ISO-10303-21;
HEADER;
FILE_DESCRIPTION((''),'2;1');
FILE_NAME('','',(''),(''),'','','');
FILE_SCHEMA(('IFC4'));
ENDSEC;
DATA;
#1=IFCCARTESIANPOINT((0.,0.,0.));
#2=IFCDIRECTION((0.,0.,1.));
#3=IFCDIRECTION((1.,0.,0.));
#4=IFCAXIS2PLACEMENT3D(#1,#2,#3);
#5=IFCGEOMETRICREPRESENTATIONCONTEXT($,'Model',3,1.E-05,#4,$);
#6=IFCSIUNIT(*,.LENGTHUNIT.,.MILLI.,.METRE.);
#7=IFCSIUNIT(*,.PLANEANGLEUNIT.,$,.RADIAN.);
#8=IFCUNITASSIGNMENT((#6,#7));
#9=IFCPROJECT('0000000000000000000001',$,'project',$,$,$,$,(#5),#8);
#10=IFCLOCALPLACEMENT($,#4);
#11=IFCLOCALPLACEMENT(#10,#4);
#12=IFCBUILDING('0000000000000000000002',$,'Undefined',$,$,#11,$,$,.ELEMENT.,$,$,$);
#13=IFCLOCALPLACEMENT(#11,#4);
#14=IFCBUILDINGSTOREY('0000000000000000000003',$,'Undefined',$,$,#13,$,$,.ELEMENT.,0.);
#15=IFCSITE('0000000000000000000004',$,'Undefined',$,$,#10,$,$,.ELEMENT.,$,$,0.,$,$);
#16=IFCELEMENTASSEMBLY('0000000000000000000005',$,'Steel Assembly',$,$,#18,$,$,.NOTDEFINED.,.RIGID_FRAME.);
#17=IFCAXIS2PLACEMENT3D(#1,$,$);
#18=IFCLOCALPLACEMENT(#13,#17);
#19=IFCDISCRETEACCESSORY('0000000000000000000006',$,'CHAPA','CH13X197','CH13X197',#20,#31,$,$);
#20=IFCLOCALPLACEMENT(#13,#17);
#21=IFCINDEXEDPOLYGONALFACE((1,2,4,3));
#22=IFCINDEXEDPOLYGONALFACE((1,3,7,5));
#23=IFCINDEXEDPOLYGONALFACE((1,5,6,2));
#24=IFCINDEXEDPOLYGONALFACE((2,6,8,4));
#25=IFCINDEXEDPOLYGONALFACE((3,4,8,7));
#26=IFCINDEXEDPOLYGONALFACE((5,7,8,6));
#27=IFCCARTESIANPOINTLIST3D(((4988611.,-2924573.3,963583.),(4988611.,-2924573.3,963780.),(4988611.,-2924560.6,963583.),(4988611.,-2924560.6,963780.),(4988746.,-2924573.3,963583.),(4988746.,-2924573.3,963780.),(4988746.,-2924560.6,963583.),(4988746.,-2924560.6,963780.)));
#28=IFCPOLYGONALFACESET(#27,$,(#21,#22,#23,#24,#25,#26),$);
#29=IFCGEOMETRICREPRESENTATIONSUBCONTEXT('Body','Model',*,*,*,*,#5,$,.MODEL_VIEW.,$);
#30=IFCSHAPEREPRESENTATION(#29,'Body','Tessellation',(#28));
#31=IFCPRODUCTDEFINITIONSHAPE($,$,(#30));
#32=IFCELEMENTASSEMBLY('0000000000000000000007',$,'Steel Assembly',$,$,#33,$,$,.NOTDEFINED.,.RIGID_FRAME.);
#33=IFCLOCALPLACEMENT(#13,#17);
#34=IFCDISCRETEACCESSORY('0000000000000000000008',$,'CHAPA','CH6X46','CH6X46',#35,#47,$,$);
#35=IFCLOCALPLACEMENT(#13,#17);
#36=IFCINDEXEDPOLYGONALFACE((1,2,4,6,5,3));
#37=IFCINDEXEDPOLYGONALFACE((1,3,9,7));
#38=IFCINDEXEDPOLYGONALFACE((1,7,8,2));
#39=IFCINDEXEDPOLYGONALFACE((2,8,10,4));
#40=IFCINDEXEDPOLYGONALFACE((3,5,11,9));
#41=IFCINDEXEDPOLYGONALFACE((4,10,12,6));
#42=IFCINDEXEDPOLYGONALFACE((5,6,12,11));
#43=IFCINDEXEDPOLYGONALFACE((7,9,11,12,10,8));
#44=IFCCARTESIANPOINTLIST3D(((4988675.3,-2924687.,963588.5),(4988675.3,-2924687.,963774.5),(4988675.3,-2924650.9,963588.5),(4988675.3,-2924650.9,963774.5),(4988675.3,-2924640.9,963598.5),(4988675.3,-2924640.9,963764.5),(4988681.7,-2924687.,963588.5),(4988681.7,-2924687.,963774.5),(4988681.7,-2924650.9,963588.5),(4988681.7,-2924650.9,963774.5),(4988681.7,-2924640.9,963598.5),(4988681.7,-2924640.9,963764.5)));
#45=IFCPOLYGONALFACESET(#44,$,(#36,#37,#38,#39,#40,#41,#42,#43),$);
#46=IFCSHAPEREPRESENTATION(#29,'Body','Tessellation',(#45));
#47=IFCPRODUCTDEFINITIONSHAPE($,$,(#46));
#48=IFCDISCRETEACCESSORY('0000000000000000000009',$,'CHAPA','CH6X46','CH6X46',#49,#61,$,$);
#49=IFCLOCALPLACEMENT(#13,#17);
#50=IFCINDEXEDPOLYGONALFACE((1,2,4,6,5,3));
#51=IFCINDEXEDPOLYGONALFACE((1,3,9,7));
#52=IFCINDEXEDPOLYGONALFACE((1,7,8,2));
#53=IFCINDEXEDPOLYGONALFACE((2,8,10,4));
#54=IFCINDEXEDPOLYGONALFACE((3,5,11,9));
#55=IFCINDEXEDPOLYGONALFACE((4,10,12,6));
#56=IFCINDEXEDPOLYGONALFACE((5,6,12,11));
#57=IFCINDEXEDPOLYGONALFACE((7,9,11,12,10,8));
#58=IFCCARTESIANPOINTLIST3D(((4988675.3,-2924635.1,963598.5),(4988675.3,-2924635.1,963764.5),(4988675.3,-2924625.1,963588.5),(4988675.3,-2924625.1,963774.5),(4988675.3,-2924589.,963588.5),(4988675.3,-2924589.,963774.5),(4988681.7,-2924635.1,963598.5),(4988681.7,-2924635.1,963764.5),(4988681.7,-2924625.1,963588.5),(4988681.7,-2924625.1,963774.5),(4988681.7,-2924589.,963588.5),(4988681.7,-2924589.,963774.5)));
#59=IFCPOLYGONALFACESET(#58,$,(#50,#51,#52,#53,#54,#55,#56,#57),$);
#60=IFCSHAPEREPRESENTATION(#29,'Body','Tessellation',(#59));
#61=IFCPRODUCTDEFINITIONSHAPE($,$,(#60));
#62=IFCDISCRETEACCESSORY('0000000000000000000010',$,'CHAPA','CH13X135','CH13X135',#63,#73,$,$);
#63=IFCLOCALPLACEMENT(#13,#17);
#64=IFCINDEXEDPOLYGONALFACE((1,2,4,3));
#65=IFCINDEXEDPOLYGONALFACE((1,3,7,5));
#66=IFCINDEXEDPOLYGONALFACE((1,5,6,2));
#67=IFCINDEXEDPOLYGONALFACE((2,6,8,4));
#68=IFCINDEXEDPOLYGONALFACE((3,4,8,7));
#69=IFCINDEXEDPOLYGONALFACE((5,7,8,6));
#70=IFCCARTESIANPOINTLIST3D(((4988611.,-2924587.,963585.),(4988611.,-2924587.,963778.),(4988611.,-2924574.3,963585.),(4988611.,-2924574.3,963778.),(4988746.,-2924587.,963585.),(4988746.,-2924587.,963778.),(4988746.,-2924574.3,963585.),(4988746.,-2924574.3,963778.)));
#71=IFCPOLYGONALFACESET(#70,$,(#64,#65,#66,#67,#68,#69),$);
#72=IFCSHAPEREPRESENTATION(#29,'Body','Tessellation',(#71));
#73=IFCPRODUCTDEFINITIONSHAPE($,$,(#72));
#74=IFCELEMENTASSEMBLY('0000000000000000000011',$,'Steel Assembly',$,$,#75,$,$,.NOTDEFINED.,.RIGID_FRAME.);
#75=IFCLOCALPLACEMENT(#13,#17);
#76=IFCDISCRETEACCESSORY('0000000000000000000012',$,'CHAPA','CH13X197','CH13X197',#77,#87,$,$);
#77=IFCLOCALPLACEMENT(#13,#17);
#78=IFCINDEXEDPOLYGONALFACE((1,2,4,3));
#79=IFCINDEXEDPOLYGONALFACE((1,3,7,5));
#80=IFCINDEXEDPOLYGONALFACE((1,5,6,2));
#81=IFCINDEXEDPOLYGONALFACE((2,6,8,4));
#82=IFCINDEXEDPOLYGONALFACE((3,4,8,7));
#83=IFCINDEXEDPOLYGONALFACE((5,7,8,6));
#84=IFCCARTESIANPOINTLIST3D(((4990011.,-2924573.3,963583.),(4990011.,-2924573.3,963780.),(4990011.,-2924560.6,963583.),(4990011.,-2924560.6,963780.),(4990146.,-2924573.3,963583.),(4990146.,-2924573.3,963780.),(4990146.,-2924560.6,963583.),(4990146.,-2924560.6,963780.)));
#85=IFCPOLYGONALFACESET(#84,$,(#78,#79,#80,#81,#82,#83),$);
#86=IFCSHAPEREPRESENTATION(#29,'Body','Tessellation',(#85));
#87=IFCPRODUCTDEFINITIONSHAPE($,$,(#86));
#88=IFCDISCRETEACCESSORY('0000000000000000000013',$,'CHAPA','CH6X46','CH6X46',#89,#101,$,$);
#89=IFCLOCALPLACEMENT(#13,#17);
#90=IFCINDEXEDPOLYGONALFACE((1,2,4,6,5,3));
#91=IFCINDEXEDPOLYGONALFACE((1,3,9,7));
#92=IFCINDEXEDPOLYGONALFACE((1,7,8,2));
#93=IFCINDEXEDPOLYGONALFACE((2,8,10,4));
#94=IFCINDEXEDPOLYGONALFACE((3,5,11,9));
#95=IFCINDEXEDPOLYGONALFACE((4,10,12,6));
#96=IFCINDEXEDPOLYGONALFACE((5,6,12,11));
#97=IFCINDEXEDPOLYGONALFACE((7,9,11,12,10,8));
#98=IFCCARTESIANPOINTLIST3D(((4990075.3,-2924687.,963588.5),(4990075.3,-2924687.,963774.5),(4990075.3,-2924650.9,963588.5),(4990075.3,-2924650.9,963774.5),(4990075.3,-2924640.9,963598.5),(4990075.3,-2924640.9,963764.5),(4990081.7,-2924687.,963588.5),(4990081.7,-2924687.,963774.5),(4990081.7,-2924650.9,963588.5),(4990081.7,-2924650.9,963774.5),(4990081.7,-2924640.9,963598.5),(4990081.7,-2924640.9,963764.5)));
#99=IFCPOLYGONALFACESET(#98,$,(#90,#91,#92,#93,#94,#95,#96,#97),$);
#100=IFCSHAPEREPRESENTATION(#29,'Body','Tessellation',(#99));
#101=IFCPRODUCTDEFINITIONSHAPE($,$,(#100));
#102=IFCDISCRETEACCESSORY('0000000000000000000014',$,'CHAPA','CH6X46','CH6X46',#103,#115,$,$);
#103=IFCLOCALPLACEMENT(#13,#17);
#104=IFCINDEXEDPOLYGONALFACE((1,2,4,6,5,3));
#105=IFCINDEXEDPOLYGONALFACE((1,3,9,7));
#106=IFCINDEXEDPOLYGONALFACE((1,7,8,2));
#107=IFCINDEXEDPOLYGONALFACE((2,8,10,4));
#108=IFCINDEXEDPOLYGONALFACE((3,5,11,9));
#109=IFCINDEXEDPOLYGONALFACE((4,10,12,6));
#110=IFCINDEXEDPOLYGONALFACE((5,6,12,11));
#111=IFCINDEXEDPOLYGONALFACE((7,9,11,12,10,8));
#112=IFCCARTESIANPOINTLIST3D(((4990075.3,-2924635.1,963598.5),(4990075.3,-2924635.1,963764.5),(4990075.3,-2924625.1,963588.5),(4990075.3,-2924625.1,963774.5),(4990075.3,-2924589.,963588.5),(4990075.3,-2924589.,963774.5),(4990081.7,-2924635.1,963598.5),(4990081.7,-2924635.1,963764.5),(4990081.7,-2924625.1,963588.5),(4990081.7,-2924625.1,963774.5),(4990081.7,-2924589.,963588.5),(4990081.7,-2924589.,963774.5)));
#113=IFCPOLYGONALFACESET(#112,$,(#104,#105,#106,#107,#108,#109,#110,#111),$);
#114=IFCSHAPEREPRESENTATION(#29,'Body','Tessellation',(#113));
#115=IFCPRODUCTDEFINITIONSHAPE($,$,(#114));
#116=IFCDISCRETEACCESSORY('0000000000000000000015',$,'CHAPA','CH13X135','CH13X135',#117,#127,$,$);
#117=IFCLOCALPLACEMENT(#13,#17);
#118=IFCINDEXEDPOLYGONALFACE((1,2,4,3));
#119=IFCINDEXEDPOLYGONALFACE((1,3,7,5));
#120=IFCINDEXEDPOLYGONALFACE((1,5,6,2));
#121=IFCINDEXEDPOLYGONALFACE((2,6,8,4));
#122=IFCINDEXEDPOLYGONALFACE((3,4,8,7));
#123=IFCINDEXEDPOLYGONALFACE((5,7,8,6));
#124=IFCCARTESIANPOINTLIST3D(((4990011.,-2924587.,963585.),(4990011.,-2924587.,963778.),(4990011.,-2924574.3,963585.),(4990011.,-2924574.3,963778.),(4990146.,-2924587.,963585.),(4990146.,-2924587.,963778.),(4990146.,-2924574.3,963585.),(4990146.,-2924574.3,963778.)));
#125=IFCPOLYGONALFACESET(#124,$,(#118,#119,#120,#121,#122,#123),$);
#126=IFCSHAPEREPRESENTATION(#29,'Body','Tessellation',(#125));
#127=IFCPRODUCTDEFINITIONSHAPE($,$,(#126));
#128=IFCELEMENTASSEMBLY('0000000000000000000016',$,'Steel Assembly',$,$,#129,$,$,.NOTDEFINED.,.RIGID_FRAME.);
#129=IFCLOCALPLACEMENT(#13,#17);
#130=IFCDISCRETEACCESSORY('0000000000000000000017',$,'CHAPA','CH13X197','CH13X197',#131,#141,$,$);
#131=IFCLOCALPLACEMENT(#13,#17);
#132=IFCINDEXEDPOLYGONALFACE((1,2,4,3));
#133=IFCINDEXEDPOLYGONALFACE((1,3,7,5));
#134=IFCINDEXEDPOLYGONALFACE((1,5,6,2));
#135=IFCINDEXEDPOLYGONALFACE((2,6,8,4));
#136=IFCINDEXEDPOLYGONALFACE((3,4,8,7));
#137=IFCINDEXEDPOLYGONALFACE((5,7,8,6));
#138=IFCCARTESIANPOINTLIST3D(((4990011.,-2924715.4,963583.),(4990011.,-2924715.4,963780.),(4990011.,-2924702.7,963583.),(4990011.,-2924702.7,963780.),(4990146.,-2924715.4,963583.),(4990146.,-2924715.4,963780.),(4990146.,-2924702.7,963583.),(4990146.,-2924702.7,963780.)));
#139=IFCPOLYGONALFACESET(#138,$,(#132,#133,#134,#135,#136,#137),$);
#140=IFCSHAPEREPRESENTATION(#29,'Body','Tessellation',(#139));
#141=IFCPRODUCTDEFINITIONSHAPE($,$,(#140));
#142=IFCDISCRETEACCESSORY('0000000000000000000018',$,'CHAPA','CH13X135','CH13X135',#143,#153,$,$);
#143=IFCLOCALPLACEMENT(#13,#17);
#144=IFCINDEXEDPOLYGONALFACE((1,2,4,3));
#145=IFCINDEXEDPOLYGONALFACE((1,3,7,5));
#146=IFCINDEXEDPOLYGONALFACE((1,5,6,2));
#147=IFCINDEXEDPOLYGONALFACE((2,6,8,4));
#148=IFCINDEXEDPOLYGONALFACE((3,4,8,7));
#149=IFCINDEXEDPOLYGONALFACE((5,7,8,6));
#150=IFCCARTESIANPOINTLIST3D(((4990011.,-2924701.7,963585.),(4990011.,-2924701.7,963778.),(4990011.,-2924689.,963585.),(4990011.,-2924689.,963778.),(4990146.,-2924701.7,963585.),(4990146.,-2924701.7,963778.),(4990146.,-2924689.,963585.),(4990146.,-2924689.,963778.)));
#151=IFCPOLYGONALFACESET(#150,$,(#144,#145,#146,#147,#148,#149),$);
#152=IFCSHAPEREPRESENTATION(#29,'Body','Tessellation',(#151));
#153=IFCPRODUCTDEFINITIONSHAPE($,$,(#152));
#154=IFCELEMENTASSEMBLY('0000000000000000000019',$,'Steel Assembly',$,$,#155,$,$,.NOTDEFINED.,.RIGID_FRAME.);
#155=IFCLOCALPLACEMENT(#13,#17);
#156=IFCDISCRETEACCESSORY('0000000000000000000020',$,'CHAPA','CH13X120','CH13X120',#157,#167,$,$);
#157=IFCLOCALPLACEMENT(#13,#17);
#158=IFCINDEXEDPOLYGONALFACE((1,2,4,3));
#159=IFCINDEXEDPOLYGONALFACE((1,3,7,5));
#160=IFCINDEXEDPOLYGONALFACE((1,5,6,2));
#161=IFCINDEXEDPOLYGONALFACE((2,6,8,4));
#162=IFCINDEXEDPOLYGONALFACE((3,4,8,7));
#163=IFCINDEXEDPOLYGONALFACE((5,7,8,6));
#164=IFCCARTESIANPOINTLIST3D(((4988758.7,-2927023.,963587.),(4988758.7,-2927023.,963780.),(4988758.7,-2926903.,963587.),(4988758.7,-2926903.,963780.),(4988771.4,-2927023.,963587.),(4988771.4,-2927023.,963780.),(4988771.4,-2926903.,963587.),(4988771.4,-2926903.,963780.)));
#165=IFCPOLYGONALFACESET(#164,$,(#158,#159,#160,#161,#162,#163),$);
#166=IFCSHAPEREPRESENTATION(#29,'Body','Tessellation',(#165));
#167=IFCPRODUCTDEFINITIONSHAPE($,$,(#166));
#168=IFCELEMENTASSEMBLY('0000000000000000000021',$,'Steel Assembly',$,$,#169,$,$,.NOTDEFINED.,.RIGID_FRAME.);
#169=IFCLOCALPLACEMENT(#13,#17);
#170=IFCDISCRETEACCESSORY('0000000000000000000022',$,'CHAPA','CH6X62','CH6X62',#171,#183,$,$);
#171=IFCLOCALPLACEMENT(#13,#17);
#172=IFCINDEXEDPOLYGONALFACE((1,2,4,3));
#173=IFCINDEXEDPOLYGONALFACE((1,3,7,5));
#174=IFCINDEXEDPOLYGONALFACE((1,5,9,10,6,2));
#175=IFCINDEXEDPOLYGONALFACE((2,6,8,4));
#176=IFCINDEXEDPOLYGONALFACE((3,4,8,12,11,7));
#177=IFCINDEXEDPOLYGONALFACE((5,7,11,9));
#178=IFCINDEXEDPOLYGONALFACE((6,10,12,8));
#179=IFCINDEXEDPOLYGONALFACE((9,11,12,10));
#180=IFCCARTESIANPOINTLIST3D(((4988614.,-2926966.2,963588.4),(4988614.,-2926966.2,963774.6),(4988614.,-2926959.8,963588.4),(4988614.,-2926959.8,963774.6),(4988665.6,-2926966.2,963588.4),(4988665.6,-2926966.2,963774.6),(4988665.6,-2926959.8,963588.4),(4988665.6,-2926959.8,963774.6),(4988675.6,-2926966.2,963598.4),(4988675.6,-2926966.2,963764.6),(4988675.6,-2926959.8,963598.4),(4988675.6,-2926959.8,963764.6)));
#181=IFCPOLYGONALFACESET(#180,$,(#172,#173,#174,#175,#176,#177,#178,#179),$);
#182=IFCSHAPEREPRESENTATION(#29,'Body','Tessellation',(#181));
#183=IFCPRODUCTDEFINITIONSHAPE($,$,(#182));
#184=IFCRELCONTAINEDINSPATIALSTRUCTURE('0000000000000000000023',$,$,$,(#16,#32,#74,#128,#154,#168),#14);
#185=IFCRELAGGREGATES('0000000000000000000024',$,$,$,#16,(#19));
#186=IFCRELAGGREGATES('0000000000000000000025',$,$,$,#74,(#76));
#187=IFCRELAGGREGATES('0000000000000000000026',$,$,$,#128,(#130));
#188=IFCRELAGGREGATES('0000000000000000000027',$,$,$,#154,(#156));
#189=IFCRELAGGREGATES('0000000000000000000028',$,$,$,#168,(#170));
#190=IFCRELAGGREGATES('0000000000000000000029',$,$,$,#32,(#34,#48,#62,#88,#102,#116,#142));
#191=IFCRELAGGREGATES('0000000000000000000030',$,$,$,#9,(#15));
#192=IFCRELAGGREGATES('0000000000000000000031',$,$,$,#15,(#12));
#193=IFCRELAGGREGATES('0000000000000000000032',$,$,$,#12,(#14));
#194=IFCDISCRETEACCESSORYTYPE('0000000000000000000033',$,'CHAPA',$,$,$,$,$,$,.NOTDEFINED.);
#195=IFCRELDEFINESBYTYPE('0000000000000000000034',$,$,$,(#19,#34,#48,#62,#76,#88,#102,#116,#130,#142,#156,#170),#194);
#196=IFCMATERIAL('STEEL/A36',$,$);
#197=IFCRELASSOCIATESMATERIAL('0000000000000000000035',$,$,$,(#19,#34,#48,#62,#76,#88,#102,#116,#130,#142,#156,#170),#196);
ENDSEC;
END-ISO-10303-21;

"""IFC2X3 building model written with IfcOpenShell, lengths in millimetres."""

from ifc_helpers import new_model, si_unit, frame, origin_with_axes, place, context, subcontext, project, spatial, polyline, outline, extrude, material, type_object, element, aggregate, save


model = new_model("IFC2X3")

# Units and contexts
model_context = context("Model", 3, precision=1e-05, world=origin_with_axes())
body_context = subcontext(model_context, "Body", "Model", "MODEL_VIEW")
ifc_project = project(units=[si_unit("LENGTHUNIT", "METRE", prefix="MILLI"), si_unit("PLANEANGLEUNIT", "RADIAN")], contexts=[model_context])

# Site, building, storey
site_placement = place(None, origin_with_axes())
site = spatial("IfcSite", under=ifc_project, at=site_placement, Name="Undefined", CompositionType="ELEMENT", RefElevation=0.0)
building_placement = place(site_placement, origin_with_axes())
building = spatial("IfcBuilding", under=site, at=building_placement, Name="Undefined", CompositionType="ELEMENT")
storey_placement = place(building_placement, origin_with_axes())
storey = spatial("IfcBuildingStorey", under=building, at=storey_placement, Name="Undefined", CompositionType="ELEMENT", Elevation=0.0)

# Element assembly, discrete accessory
assembly_1_placement = place(storey_placement, origin_with_axes())
assembly_1 = element("IfcElementAssembly", 1, at=assembly_1_placement, inside=storey, Name="Steel Assembly", AssemblyPlace="NOTDEFINED", PredefinedType="RIGID_FRAME")
ifc_material_1 = material(Name="STEEL/A36")
discrete_accessory_type_1 = type_object("IfcDiscreteAccessoryType", Name="CHAPA")
discrete_accessory_1_placement = place(assembly_1_placement, frame((4988678.5, -2924567.0, 963780.0), z_axis=(0.0, 1.0, 0.0), x_axis=(0.0, 0.0, -1.0)))
discrete_accessory_1 = element("IfcDiscreteAccessory", 2, at=discrete_accessory_1_placement, type_object=discrete_accessory_type_1, material=ifc_material_1, Name="CHAPA", Description="CH13X197", ObjectType="CH13X197", context=body_context, shape_type="SweptSolid", body=[
    extrude(outline(polyline([(197.0, 67.5), (197.0, -67.5), (0.0, -67.5), (0.0, 67.5), (197.0, 67.5)])), frame((0.0, 0.0, -6.3), z_axis=(0.0, 0.0, 1.0), x_axis=(1.0, 0.0, 0.0)), (0.0, 0.0, 1.0), 12.7),
])
aggregate(assembly_1, [discrete_accessory_1])

# Element assembly, discrete accessories
assembly_2_placement = place(storey_placement, origin_with_axes())
assembly_2 = element("IfcElementAssembly", 3, at=assembly_2_placement, inside=storey, Name="Steel Assembly", AssemblyPlace="NOTDEFINED", PredefinedType="RIGID_FRAME")
discrete_accessory_2_placement = place(assembly_2_placement, frame((4988678.5, -2924640.9, 963774.5), z_axis=(1.0, 0.0, 0.0), x_axis=(0.0, -1.0, 0.0)))
discrete_accessory_2 = element("IfcDiscreteAccessory", 4, at=discrete_accessory_2_placement, type_object=discrete_accessory_type_1, material=ifc_material_1, Name="CHAPA", Description="CH6X46", ObjectType="CH6X46", context=body_context, shape_type="SweptSolid", body=[
    extrude(outline(polyline([(0.0, 10.0), (10.0, 0.0), (46.1, 0.0), (46.1, 186.0), (10.0, 186.0), (0.0, 176.0), (0.0, 10.0)])), frame((0.0, 0.0, -3.2), z_axis=(0.0, 0.0, 1.0), x_axis=(1.0, 0.0, 0.0)), (0.0, 0.0, 1.0), 6.4),
])
discrete_accessory_3_placement = place(assembly_2_placement, frame((4988678.5, -2924635.1, 963774.5), z_axis=(-1.0, 0.0, 0.0), x_axis=(0.0, 1.0, 0.0)))
discrete_accessory_3 = element("IfcDiscreteAccessory", 5, at=discrete_accessory_3_placement, type_object=discrete_accessory_type_1, material=ifc_material_1, Name="CHAPA", Description="CH6X46", ObjectType="CH6X46", context=body_context, shape_type="SweptSolid", body=[
    extrude(outline(polyline([(0.0, 10.0), (10.0, 0.0), (46.1, 0.0), (46.1, 186.0), (10.0, 186.0), (0.0, 176.0), (0.0, 10.0)])), frame((0.0, 0.0, -3.2), z_axis=(0.0, 0.0, 1.0), x_axis=(1.0, 0.0, 0.0)), (0.0, 0.0, 1.0), 6.4),
])
discrete_accessory_4_placement = place(assembly_2_placement, frame((4988678.5, -2924580.7, 963778.0), z_axis=(0.0, 1.0, 0.0), x_axis=(0.0, 0.0, -1.0)))
discrete_accessory_4 = element("IfcDiscreteAccessory", 6, at=discrete_accessory_4_placement, type_object=discrete_accessory_type_1, material=ifc_material_1, Name="CHAPA", Description="CH13X135", ObjectType="CH13X135", context=body_context, shape_type="SweptSolid", body=[
    extrude(outline(polyline([(193.0, 67.5), (193.0, -67.5), (0.0, -67.5), (0.0, 67.5), (193.0, 67.5)])), frame((0.0, 0.0, -6.3), z_axis=(0.0, 0.0, 1.0), x_axis=(1.0, 0.0, 0.0)), (0.0, 0.0, 1.0), 12.7),
])

# Element assembly, discrete accessory
assembly_3_placement = place(storey_placement, origin_with_axes())
assembly_3 = element("IfcElementAssembly", 7, at=assembly_3_placement, inside=storey, Name="Steel Assembly", AssemblyPlace="NOTDEFINED", PredefinedType="RIGID_FRAME")
discrete_accessory_5_placement = place(assembly_3_placement, frame((4990078.5, -2924567.0, 963780.0), z_axis=(0.0, 1.0, 0.0), x_axis=(0.0, 0.0, -1.0)))
discrete_accessory_5 = element("IfcDiscreteAccessory", 8, at=discrete_accessory_5_placement, type_object=discrete_accessory_type_1, material=ifc_material_1, Name="CHAPA", Description="CH13X197", ObjectType="CH13X197", context=body_context, shape_type="SweptSolid", body=[
    extrude(outline(polyline([(197.0, 67.5), (197.0, -67.5), (0.0, -67.5), (0.0, 67.5), (197.0, 67.5)])), frame((0.0, 0.0, -6.3), z_axis=(0.0, 0.0, 1.0), x_axis=(1.0, 0.0, 0.0)), (0.0, 0.0, 1.0), 12.7),
])
aggregate(assembly_3, [discrete_accessory_5])

# Discrete accessories
discrete_accessory_6_placement = place(assembly_2_placement, frame((4990078.5, -2924640.9, 963774.5), z_axis=(1.0, 0.0, 0.0), x_axis=(0.0, -1.0, 0.0)))
discrete_accessory_6 = element("IfcDiscreteAccessory", 9, at=discrete_accessory_6_placement, type_object=discrete_accessory_type_1, material=ifc_material_1, Name="CHAPA", Description="CH6X46", ObjectType="CH6X46", context=body_context, shape_type="SweptSolid", body=[
    extrude(outline(polyline([(0.0, 10.0), (10.0, 0.0), (46.1, 0.0), (46.1, 186.0), (10.0, 186.0), (0.0, 176.0), (0.0, 10.0)])), frame((0.0, 0.0, -3.2), z_axis=(0.0, 0.0, 1.0), x_axis=(1.0, 0.0, 0.0)), (0.0, 0.0, 1.0), 6.4),
])
discrete_accessory_7_placement = place(assembly_2_placement, frame((4990078.5, -2924635.1, 963774.5), z_axis=(-1.0, 0.0, 0.0), x_axis=(0.0, 1.0, 0.0)))
discrete_accessory_7 = element("IfcDiscreteAccessory", 10, at=discrete_accessory_7_placement, type_object=discrete_accessory_type_1, material=ifc_material_1, Name="CHAPA", Description="CH6X46", ObjectType="CH6X46", context=body_context, shape_type="SweptSolid", body=[
    extrude(outline(polyline([(0.0, 10.0), (10.0, 0.0), (46.1, 0.0), (46.1, 186.0), (10.0, 186.0), (0.0, 176.0), (0.0, 10.0)])), frame((0.0, 0.0, -3.2), z_axis=(0.0, 0.0, 1.0), x_axis=(1.0, 0.0, 0.0)), (0.0, 0.0, 1.0), 6.4),
])
discrete_accessory_8_placement = place(assembly_2_placement, frame((4990078.5, -2924580.7, 963778.0), z_axis=(0.0, 1.0, 0.0), x_axis=(0.0, 0.0, -1.0)))
discrete_accessory_8 = element("IfcDiscreteAccessory", 11, at=discrete_accessory_8_placement, type_object=discrete_accessory_type_1, material=ifc_material_1, Name="CHAPA", Description="CH13X135", ObjectType="CH13X135", context=body_context, shape_type="SweptSolid", body=[
    extrude(outline(polyline([(193.0, 67.5), (193.0, -67.5), (0.0, -67.5), (0.0, 67.5), (193.0, 67.5)])), frame((0.0, 0.0, -6.3), z_axis=(0.0, 0.0, 1.0), x_axis=(1.0, 0.0, 0.0)), (0.0, 0.0, 1.0), 12.7),
])

# Element assembly, discrete accessory
assembly_4_placement = place(storey_placement, origin_with_axes())
assembly_4 = element("IfcElementAssembly", 12, at=assembly_4_placement, inside=storey, Name="Steel Assembly", AssemblyPlace="NOTDEFINED", PredefinedType="RIGID_FRAME")
discrete_accessory_9_placement = place(assembly_4_placement, frame((4990078.5, -2924709.1, 963780.0), z_axis=(0.0, -1.0, 0.0), x_axis=(0.0, 0.0, -1.0)))
discrete_accessory_9 = element("IfcDiscreteAccessory", 13, at=discrete_accessory_9_placement, type_object=discrete_accessory_type_1, material=ifc_material_1, Name="CHAPA", Description="CH13X197", ObjectType="CH13X197", context=body_context, shape_type="SweptSolid", body=[
    extrude(outline(polyline([(197.0, -67.5), (0.0, -67.5), (0.0, 67.5), (197.0, 67.5), (197.0, -67.5)])), frame((0.0, 0.0, -6.3), z_axis=(0.0, 0.0, 1.0), x_axis=(1.0, 0.0, 0.0)), (0.0, 0.0, 1.0), 12.7),
])
aggregate(assembly_4, [discrete_accessory_9])

# Discrete accessory
discrete_accessory_10_placement = place(assembly_2_placement, frame((4990078.5, -2924695.4, 963778.0), z_axis=(0.0, -1.0, 0.0), x_axis=(0.0, 0.0, -1.0)))
discrete_accessory_10 = element("IfcDiscreteAccessory", 14, at=discrete_accessory_10_placement, type_object=discrete_accessory_type_1, material=ifc_material_1, Name="CHAPA", Description="CH13X135", ObjectType="CH13X135", context=body_context, shape_type="SweptSolid", body=[
    extrude(outline(polyline([(193.0, -67.5), (0.0, -67.5), (0.0, 67.5), (193.0, 67.5), (193.0, -67.5)])), frame((0.0, 0.0, -6.3), z_axis=(0.0, 0.0, 1.0), x_axis=(1.0, 0.0, 0.0)), (0.0, 0.0, 1.0), 12.7),
])

# Element assembly, discrete accessory
assembly_5_placement = place(storey_placement, origin_with_axes())
assembly_5 = element("IfcElementAssembly", 15, at=assembly_5_placement, inside=storey, Name="Steel Assembly", AssemblyPlace="NOTDEFINED", PredefinedType="RIGID_FRAME")
discrete_accessory_11_placement = place(assembly_5_placement, frame((4988765.0, -2926963.0, 963780.0), z_axis=(1.0, 0.0, 0.0), x_axis=(0.0, 0.0, -1.0)))
discrete_accessory_11 = element("IfcDiscreteAccessory", 16, at=discrete_accessory_11_placement, type_object=discrete_accessory_type_1, material=ifc_material_1, Name="CHAPA", Description="CH13X120", ObjectType="CH13X120", context=body_context, shape_type="SweptSolid", body=[
    extrude(outline(polyline([(193.0, -60.0), (0.0, -60.0), (0.0, 60.0), (193.0, 60.0), (193.0, -60.0)])), frame((0.0, 0.0, -6.3), z_axis=(0.0, 0.0, 1.0), x_axis=(1.0, 0.0, 0.0)), (0.0, 0.0, 1.0), 12.7),
])
aggregate(assembly_5, [discrete_accessory_11])

# Element assembly, discrete accessory
assembly_6_placement = place(storey_placement, origin_with_axes())
assembly_6 = element("IfcElementAssembly", 17, at=assembly_6_placement, inside=storey, Name="Steel Assembly", AssemblyPlace="NOTDEFINED", PredefinedType="RIGID_FRAME")
discrete_accessory_12_placement = place(assembly_6_placement, frame((4988675.6, -2926963.0, 963774.6), z_axis=(0.0, -1.0, 0.0), x_axis=(-1.0, 0.0, 0.0)))
discrete_accessory_12 = element("IfcDiscreteAccessory", 18, at=discrete_accessory_12_placement, type_object=discrete_accessory_type_1, material=ifc_material_1, Name="CHAPA", Description="CH6X62", ObjectType="CH6X62", context=body_context, shape_type="SweptSolid", body=[
    extrude(outline(polyline([(0.0, 10.0), (10.0, 0.0), (61.6, 0.0), (61.6, 186.2), (10.0, 186.2), (0.0, 176.2), (0.0, 10.0)])), frame((0.0, 0.0, -3.2), z_axis=(0.0, 0.0, 1.0), x_axis=(1.0, 0.0, 0.0)), (0.0, 0.0, 1.0), 6.4),
])
aggregate(assembly_6, [discrete_accessory_12])

aggregate(assembly_2, [discrete_accessory_2, discrete_accessory_3, discrete_accessory_4, discrete_accessory_6, discrete_accessory_7, discrete_accessory_8, discrete_accessory_10])

save(model, "model.ifc")
